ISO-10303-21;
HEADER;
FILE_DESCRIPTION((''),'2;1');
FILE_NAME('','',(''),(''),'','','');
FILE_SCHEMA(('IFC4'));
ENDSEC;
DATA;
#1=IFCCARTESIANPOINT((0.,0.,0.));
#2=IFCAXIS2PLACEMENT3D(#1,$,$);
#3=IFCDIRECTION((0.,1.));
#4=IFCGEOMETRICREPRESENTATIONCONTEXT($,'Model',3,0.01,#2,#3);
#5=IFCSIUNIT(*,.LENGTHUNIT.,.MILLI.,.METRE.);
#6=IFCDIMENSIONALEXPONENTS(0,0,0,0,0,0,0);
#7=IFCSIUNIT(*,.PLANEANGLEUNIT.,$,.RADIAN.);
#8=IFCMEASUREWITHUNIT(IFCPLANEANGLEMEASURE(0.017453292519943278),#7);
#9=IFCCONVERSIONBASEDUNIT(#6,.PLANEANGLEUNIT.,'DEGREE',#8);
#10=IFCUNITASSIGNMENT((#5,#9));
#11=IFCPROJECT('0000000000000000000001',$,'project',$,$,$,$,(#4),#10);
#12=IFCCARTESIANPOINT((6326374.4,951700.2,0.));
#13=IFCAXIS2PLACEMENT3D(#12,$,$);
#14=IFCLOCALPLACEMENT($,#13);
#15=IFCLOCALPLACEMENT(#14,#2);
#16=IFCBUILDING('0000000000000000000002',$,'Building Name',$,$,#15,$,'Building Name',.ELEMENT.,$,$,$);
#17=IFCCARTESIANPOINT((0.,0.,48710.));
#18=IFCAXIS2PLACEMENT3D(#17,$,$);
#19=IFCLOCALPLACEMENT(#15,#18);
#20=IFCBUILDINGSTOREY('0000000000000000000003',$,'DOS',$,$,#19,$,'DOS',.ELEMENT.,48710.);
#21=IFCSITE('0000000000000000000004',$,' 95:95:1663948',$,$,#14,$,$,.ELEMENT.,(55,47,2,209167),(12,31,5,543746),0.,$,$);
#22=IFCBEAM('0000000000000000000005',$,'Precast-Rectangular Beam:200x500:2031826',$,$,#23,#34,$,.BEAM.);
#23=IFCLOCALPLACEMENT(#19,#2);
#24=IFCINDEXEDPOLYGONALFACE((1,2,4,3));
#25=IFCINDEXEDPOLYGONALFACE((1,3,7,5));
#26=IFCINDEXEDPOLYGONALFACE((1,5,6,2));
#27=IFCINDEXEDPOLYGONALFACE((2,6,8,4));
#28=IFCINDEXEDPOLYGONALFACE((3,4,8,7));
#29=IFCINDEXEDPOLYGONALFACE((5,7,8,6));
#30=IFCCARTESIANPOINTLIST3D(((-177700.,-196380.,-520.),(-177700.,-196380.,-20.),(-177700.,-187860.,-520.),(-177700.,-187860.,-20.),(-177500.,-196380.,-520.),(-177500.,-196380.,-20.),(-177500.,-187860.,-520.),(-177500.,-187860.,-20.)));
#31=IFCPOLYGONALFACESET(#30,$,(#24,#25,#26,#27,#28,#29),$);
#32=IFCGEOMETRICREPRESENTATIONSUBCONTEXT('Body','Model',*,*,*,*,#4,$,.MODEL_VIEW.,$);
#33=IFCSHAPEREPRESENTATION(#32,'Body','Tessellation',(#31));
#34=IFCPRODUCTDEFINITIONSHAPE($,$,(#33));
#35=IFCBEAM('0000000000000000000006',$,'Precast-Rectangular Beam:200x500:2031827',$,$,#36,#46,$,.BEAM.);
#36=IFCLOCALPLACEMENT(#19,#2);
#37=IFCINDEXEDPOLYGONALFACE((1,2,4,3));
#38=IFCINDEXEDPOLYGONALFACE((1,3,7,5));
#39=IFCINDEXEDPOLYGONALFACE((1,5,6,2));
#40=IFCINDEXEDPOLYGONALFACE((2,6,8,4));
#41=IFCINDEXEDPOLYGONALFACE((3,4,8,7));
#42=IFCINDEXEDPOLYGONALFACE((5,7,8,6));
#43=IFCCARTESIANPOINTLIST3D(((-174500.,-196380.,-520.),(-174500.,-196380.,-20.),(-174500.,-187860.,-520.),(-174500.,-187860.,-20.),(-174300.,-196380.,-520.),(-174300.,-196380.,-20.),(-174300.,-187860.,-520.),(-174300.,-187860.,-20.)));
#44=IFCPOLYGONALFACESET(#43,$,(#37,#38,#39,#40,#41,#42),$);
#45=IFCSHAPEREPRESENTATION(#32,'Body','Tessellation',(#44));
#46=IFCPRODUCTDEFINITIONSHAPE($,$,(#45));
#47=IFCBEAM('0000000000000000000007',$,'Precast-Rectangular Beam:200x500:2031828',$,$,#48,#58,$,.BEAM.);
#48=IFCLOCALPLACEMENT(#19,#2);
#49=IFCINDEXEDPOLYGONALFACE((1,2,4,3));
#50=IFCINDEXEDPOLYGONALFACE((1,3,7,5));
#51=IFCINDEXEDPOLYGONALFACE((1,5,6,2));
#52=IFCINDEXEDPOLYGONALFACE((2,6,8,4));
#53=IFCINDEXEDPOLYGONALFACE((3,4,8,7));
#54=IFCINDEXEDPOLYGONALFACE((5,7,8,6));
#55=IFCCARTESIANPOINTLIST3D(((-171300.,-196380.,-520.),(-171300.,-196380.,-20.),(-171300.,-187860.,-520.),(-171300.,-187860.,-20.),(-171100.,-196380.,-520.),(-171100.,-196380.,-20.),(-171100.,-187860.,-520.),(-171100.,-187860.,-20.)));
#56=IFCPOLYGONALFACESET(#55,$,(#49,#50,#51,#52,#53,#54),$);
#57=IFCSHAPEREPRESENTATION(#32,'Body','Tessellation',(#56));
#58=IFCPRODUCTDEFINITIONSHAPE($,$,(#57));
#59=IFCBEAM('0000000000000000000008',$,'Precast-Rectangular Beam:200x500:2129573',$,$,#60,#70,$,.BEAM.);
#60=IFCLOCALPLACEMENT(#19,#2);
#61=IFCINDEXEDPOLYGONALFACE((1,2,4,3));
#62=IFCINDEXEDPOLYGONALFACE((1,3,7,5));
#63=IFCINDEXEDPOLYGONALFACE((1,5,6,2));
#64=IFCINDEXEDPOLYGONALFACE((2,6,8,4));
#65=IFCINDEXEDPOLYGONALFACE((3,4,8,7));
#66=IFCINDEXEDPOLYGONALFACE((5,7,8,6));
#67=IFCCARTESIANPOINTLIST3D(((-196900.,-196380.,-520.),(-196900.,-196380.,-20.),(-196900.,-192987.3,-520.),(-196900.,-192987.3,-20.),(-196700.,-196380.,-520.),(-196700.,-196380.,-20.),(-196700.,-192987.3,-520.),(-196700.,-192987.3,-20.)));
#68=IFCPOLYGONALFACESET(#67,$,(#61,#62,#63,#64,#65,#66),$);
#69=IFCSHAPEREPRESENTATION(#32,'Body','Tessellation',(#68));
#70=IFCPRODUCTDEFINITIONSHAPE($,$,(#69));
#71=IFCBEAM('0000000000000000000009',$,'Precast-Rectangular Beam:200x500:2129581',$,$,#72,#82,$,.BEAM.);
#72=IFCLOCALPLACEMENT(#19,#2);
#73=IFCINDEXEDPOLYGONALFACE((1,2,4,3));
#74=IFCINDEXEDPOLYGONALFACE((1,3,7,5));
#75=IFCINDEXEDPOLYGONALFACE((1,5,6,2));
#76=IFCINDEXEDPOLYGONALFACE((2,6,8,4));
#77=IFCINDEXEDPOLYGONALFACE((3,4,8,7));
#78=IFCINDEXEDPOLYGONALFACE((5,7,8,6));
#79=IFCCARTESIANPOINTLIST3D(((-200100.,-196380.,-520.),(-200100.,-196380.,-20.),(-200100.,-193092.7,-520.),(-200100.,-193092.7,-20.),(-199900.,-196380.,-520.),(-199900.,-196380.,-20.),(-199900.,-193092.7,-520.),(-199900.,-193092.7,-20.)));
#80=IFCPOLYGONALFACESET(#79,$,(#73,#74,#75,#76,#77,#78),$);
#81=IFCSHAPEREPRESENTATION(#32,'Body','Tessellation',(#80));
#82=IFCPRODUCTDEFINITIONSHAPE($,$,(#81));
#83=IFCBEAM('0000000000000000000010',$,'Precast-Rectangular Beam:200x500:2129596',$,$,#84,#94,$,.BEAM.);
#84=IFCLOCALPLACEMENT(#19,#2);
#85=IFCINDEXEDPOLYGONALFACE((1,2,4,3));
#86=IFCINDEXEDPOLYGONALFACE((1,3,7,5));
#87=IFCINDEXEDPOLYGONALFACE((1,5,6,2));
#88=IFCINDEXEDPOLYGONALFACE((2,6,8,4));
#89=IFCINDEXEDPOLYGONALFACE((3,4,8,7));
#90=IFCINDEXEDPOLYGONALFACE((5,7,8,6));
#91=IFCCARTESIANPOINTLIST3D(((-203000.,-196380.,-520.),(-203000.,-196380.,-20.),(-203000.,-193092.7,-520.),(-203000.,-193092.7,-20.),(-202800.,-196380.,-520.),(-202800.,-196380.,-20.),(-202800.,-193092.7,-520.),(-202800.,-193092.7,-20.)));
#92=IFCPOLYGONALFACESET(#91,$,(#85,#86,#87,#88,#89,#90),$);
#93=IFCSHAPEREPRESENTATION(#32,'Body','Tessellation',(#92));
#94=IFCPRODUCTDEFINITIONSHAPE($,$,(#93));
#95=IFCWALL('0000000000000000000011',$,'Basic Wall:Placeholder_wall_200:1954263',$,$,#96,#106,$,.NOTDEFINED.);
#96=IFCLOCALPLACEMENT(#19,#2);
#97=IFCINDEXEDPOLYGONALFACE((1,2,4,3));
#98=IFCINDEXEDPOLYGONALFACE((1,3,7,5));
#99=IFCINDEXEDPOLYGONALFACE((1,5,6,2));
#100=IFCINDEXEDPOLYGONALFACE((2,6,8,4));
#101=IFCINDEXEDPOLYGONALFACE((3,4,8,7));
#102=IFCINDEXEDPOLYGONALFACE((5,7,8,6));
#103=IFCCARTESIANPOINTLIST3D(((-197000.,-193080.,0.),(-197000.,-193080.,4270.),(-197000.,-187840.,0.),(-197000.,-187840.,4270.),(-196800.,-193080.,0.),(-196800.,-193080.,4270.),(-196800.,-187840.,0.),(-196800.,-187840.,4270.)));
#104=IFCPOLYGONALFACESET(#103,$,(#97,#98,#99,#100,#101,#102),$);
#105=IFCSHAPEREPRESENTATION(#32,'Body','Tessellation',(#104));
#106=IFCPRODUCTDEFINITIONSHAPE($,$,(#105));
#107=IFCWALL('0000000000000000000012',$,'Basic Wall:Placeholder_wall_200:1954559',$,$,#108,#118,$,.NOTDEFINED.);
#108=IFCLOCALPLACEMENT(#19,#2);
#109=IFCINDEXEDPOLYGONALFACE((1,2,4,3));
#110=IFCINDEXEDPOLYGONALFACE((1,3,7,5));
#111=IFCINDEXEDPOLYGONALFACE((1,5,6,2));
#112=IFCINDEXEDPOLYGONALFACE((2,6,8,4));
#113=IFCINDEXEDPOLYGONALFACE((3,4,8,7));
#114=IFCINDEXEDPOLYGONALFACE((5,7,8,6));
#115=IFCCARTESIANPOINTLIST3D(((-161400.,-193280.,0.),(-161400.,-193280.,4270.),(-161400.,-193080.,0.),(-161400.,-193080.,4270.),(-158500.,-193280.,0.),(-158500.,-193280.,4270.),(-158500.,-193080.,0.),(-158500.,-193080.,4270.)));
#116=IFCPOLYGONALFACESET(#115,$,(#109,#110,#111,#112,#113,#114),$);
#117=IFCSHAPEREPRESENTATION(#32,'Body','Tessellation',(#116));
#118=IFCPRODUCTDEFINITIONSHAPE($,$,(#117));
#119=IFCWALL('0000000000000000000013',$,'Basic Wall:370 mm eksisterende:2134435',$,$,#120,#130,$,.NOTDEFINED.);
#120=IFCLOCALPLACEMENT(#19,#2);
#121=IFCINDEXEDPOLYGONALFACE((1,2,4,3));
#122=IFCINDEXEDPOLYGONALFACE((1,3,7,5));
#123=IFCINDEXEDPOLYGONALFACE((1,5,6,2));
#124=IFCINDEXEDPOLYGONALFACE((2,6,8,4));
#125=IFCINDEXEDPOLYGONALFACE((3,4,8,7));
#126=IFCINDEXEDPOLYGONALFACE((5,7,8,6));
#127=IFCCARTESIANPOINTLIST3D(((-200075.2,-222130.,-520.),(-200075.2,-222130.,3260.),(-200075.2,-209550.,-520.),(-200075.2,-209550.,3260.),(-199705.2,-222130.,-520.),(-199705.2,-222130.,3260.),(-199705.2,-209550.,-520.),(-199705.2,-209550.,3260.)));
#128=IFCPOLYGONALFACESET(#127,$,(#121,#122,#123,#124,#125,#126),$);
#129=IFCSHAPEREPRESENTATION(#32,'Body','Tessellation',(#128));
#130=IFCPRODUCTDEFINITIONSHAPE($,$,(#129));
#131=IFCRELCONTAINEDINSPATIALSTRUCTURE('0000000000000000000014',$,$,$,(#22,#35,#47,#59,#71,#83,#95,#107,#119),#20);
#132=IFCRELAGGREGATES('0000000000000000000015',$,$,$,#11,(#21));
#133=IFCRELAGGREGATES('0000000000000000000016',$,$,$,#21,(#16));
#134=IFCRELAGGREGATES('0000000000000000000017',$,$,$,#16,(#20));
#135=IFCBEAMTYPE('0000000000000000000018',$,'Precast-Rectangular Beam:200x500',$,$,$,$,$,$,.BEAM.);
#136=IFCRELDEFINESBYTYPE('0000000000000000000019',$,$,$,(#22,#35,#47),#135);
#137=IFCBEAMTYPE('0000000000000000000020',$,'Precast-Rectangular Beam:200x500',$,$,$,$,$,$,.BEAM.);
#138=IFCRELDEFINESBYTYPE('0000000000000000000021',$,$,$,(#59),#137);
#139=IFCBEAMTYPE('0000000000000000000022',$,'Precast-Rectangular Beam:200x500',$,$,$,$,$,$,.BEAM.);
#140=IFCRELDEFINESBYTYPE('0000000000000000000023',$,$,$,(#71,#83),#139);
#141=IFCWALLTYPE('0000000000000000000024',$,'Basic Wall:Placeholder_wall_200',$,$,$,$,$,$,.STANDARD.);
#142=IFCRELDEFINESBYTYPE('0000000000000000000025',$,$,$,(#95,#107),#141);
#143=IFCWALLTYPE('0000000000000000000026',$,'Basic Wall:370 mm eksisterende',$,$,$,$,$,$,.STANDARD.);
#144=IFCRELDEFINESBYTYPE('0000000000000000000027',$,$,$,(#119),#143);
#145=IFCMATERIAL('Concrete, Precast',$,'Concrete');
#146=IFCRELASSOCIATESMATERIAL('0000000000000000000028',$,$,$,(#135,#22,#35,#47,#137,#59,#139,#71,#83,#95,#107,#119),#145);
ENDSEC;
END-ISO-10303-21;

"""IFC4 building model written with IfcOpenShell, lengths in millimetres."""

from ifc_helpers import new_model, entity, si_unit, converted_unit, direction, frame, origin, place, context, subcontext, project, spatial, indexed_curve, outline, extrude, source, transform, mapped, material, type_object, type_shapes, element, save


model = new_model("IFC4")

# Units and contexts
model_context = context("Model", 3, precision=0.01, world=origin(), true_north=direction((0.0, 1.0)))
body_context = subcontext(model_context, "Body", "Model", "MODEL_VIEW")
ifc_project = project(units=[si_unit("LENGTHUNIT", "METRE", prefix="MILLI"), converted_unit("PLANEANGLEUNIT", "DEGREE", entity("IfcPlaneAngleMeasure", 0.017453292519943278), si_unit("PLANEANGLEUNIT", "RADIAN"), dimensions=[0, 0, 0, 0, 0, 0, 0])], contexts=[model_context])

# Site, building, storey
site_placement = place(None, frame((6326374.4, 951700.2, 0.0)))
site = spatial("IfcSite", under=ifc_project, at=site_placement, Name=" 95:95:1663948", CompositionType="ELEMENT", RefLatitude=(55, 47, 2, 209167), RefLongitude=(12, 31, 5, 543746), RefElevation=0.0)
building_placement = place(site_placement, origin())
building = spatial("IfcBuilding", under=site, at=building_placement, Name="Building Name", LongName="Building Name", CompositionType="ELEMENT")
storey_placement = place(building_placement, frame((0.0, 0.0, 48710.0)))
storey = spatial("IfcBuildingStorey", under=building, at=storey_placement, Name="DOS", LongName="DOS", CompositionType="ELEMENT", Elevation=48710.0)

# Beams
ifc_material_1 = material(Name="Concrete, Precast", Category="Concrete")
beam_type_1 = type_object("IfcBeamType", Name="Precast-Rectangular Beam:200x500", PredefinedType="BEAM", material=ifc_material_1)
shared_shape_1 = source(origin(), body_context, "Body", "SweptSolid", [
    extrude(outline(indexed_curve([(-4260.0, -100.0), (4260.0, -100.0), (4260.0, 100.0), (-4260.0, 100.0), (-4260.0, -100.0)], self_intersect=False)), frame((3.6, 0.0, -250.0), z_axis=(0.0, 0.0, 1.0), x_axis=(-1.0, 0.0, 0.0)), (0.0, 0.0, 1.0), 500.0),
])
type_shapes(beam_type_1, [shared_shape_1])
for number, where, z_axis, x_axis, name in (
    (1, (-177600.0, -192116.4, -270.0), (0.0, 0.0, 1.0), (0.0, -1.0, 0.0), "Precast-Rectangular Beam:200x500:2031826"),
    (2, (-174400.0, -192116.4, -270.0), (0.0, 0.0, 1.0), (0.0, -1.0, 0.0), "Precast-Rectangular Beam:200x500:2031827"),
    (3, (-171200.0, -192116.4, -270.0), (0.0, 0.0, 1.0), (0.0, -1.0, 0.0), "Precast-Rectangular Beam:200x500:2031828"),
):
    element("IfcBeam", number, at=place(storey_placement, frame(where, z_axis=z_axis, x_axis=x_axis)), inside=storey, type_object=beam_type_1, material=ifc_material_1, Name=name, PredefinedType="BEAM", context=body_context, shape_type="MappedRepresentation", body=[
        mapped(shared_shape_1, transform((0.0, 0.0, 0.0), scale=1.0)),
    ])
beam_type_2 = type_object("IfcBeamType", Name="Precast-Rectangular Beam:200x500", PredefinedType="BEAM", material=ifc_material_1)
shared_shape_2 = source(origin(), body_context, "Body", "SweptSolid", [
    extrude(outline(indexed_curve([(-1696.4, -100.0), (1696.4, -100.0), (1696.4, 100.0), (-1696.4, 100.0), (-1696.4, -100.0)], self_intersect=False)), frame((3.6, 0.0, -250.0), z_axis=(0.0, 0.0, 1.0), x_axis=(-1.0, 0.0, 0.0)), (0.0, 0.0, 1.0), 500.0),
])
type_shapes(beam_type_2, [shared_shape_2])
beam_placement = place(storey_placement, frame((-196800.0, -194680.0, -270.0), z_axis=(0.0, 0.0, 1.0), x_axis=(0.0, -1.0, 0.0)))
element("IfcBeam", 4, at=beam_placement, inside=storey, type_object=beam_type_2, material=ifc_material_1, Name="Precast-Rectangular Beam:200x500:2129573", PredefinedType="BEAM", context=body_context, shape_type="MappedRepresentation", body=[
    mapped(shared_shape_2, transform((0.0, 0.0, 0.0), scale=1.0)),
])
beam_type_3 = type_object("IfcBeamType", Name="Precast-Rectangular Beam:200x500", PredefinedType="BEAM", material=ifc_material_1)
shared_shape_3 = source(origin(), body_context, "Body", "SweptSolid", [
    extrude(outline(indexed_curve([(-1643.6, -100.0), (1643.6, -100.0), (1643.6, 100.0), (-1643.6, 100.0), (-1643.6, -100.0)], self_intersect=False)), frame((106.3, 0.0, -250.0), z_axis=(0.0, 0.0, 1.0), x_axis=(-1.0, 0.0, 0.0)), (0.0, 0.0, 1.0), 500.0),
])
type_shapes(beam_type_3, [shared_shape_3])
for number, where, z_axis, x_axis, name in (
    (5, (-200000.0, -194630.0, -270.0), (0.0, 0.0, 1.0), (0.0, -1.0, 0.0), "Precast-Rectangular Beam:200x500:2129581"),
    (6, (-202900.0, -194630.0, -270.0), (0.0, 0.0, 1.0), (0.0, -1.0, 0.0), "Precast-Rectangular Beam:200x500:2129596"),
):
    element("IfcBeam", number, at=place(storey_placement, frame(where, z_axis=z_axis, x_axis=x_axis)), inside=storey, type_object=beam_type_3, material=ifc_material_1, Name=name, PredefinedType="BEAM", context=body_context, shape_type="MappedRepresentation", body=[
        mapped(shared_shape_3, transform((0.0, 0.0, 0.0), scale=1.0)),
    ])

# Walls
wall_type_1 = type_object("IfcWallType", Name="Basic Wall:Placeholder_wall_200", PredefinedType="STANDARD")
wall_1_placement = place(storey_placement, frame((-196900.0, -193080.0, 0.0), z_axis=(0.0, 0.0, 1.0), x_axis=(0.0, 1.0, 0.0)))
element("IfcWall", 7, at=wall_1_placement, inside=storey, type_object=wall_type_1, material=ifc_material_1, Name="Basic Wall:Placeholder_wall_200:1954263", PredefinedType="NOTDEFINED", context=body_context, shape_type="SweptSolid", body=[
    extrude(outline(indexed_curve([(5240.0, 100.0), (0.0, 100.0), (0.0, -100.0), (5240.0, -100.0), (5240.0, 100.0)], self_intersect=False)), origin(), (0.0, 0.0, 1.0), 4270.0),
])
wall_2_placement = place(storey_placement, frame((-161400.0, -193180.0, 0.0)))
element("IfcWall", 8, at=wall_2_placement, inside=storey, type_object=wall_type_1, material=ifc_material_1, Name="Basic Wall:Placeholder_wall_200:1954559", PredefinedType="NOTDEFINED", context=body_context, shape_type="SweptSolid", body=[
    extrude(outline(indexed_curve([(2900.0, 100.0), (0.0, 100.0), (0.0, -100.0), (2900.0, -100.0), (2900.0, 100.0)], self_intersect=False)), origin(), (0.0, 0.0, 1.0), 4270.0),
])
wall_type_2 = type_object("IfcWallType", Name="Basic Wall:370 mm eksisterende", PredefinedType="STANDARD")
wall_3_placement = place(storey_placement, frame((-199890.2, -209550.0, -520.0), z_axis=(0.0, 0.0, 1.0), x_axis=(0.0, -1.0, 0.0)))
element("IfcWall", 9, at=wall_3_placement, inside=storey, type_object=wall_type_2, material=ifc_material_1, Name="Basic Wall:370 mm eksisterende:2134435", PredefinedType="NOTDEFINED", context=body_context, shape_type="SweptSolid", body=[
    extrude(outline(indexed_curve([(12580.0, 185.0), (0.0, 185.0), (0.0, -185.0), (12580.0, -185.0), (12580.0, 185.0)], self_intersect=False)), origin(), (0.0, 0.0, 1.0), 3780.0),
])

save(model, "model.ifc")
